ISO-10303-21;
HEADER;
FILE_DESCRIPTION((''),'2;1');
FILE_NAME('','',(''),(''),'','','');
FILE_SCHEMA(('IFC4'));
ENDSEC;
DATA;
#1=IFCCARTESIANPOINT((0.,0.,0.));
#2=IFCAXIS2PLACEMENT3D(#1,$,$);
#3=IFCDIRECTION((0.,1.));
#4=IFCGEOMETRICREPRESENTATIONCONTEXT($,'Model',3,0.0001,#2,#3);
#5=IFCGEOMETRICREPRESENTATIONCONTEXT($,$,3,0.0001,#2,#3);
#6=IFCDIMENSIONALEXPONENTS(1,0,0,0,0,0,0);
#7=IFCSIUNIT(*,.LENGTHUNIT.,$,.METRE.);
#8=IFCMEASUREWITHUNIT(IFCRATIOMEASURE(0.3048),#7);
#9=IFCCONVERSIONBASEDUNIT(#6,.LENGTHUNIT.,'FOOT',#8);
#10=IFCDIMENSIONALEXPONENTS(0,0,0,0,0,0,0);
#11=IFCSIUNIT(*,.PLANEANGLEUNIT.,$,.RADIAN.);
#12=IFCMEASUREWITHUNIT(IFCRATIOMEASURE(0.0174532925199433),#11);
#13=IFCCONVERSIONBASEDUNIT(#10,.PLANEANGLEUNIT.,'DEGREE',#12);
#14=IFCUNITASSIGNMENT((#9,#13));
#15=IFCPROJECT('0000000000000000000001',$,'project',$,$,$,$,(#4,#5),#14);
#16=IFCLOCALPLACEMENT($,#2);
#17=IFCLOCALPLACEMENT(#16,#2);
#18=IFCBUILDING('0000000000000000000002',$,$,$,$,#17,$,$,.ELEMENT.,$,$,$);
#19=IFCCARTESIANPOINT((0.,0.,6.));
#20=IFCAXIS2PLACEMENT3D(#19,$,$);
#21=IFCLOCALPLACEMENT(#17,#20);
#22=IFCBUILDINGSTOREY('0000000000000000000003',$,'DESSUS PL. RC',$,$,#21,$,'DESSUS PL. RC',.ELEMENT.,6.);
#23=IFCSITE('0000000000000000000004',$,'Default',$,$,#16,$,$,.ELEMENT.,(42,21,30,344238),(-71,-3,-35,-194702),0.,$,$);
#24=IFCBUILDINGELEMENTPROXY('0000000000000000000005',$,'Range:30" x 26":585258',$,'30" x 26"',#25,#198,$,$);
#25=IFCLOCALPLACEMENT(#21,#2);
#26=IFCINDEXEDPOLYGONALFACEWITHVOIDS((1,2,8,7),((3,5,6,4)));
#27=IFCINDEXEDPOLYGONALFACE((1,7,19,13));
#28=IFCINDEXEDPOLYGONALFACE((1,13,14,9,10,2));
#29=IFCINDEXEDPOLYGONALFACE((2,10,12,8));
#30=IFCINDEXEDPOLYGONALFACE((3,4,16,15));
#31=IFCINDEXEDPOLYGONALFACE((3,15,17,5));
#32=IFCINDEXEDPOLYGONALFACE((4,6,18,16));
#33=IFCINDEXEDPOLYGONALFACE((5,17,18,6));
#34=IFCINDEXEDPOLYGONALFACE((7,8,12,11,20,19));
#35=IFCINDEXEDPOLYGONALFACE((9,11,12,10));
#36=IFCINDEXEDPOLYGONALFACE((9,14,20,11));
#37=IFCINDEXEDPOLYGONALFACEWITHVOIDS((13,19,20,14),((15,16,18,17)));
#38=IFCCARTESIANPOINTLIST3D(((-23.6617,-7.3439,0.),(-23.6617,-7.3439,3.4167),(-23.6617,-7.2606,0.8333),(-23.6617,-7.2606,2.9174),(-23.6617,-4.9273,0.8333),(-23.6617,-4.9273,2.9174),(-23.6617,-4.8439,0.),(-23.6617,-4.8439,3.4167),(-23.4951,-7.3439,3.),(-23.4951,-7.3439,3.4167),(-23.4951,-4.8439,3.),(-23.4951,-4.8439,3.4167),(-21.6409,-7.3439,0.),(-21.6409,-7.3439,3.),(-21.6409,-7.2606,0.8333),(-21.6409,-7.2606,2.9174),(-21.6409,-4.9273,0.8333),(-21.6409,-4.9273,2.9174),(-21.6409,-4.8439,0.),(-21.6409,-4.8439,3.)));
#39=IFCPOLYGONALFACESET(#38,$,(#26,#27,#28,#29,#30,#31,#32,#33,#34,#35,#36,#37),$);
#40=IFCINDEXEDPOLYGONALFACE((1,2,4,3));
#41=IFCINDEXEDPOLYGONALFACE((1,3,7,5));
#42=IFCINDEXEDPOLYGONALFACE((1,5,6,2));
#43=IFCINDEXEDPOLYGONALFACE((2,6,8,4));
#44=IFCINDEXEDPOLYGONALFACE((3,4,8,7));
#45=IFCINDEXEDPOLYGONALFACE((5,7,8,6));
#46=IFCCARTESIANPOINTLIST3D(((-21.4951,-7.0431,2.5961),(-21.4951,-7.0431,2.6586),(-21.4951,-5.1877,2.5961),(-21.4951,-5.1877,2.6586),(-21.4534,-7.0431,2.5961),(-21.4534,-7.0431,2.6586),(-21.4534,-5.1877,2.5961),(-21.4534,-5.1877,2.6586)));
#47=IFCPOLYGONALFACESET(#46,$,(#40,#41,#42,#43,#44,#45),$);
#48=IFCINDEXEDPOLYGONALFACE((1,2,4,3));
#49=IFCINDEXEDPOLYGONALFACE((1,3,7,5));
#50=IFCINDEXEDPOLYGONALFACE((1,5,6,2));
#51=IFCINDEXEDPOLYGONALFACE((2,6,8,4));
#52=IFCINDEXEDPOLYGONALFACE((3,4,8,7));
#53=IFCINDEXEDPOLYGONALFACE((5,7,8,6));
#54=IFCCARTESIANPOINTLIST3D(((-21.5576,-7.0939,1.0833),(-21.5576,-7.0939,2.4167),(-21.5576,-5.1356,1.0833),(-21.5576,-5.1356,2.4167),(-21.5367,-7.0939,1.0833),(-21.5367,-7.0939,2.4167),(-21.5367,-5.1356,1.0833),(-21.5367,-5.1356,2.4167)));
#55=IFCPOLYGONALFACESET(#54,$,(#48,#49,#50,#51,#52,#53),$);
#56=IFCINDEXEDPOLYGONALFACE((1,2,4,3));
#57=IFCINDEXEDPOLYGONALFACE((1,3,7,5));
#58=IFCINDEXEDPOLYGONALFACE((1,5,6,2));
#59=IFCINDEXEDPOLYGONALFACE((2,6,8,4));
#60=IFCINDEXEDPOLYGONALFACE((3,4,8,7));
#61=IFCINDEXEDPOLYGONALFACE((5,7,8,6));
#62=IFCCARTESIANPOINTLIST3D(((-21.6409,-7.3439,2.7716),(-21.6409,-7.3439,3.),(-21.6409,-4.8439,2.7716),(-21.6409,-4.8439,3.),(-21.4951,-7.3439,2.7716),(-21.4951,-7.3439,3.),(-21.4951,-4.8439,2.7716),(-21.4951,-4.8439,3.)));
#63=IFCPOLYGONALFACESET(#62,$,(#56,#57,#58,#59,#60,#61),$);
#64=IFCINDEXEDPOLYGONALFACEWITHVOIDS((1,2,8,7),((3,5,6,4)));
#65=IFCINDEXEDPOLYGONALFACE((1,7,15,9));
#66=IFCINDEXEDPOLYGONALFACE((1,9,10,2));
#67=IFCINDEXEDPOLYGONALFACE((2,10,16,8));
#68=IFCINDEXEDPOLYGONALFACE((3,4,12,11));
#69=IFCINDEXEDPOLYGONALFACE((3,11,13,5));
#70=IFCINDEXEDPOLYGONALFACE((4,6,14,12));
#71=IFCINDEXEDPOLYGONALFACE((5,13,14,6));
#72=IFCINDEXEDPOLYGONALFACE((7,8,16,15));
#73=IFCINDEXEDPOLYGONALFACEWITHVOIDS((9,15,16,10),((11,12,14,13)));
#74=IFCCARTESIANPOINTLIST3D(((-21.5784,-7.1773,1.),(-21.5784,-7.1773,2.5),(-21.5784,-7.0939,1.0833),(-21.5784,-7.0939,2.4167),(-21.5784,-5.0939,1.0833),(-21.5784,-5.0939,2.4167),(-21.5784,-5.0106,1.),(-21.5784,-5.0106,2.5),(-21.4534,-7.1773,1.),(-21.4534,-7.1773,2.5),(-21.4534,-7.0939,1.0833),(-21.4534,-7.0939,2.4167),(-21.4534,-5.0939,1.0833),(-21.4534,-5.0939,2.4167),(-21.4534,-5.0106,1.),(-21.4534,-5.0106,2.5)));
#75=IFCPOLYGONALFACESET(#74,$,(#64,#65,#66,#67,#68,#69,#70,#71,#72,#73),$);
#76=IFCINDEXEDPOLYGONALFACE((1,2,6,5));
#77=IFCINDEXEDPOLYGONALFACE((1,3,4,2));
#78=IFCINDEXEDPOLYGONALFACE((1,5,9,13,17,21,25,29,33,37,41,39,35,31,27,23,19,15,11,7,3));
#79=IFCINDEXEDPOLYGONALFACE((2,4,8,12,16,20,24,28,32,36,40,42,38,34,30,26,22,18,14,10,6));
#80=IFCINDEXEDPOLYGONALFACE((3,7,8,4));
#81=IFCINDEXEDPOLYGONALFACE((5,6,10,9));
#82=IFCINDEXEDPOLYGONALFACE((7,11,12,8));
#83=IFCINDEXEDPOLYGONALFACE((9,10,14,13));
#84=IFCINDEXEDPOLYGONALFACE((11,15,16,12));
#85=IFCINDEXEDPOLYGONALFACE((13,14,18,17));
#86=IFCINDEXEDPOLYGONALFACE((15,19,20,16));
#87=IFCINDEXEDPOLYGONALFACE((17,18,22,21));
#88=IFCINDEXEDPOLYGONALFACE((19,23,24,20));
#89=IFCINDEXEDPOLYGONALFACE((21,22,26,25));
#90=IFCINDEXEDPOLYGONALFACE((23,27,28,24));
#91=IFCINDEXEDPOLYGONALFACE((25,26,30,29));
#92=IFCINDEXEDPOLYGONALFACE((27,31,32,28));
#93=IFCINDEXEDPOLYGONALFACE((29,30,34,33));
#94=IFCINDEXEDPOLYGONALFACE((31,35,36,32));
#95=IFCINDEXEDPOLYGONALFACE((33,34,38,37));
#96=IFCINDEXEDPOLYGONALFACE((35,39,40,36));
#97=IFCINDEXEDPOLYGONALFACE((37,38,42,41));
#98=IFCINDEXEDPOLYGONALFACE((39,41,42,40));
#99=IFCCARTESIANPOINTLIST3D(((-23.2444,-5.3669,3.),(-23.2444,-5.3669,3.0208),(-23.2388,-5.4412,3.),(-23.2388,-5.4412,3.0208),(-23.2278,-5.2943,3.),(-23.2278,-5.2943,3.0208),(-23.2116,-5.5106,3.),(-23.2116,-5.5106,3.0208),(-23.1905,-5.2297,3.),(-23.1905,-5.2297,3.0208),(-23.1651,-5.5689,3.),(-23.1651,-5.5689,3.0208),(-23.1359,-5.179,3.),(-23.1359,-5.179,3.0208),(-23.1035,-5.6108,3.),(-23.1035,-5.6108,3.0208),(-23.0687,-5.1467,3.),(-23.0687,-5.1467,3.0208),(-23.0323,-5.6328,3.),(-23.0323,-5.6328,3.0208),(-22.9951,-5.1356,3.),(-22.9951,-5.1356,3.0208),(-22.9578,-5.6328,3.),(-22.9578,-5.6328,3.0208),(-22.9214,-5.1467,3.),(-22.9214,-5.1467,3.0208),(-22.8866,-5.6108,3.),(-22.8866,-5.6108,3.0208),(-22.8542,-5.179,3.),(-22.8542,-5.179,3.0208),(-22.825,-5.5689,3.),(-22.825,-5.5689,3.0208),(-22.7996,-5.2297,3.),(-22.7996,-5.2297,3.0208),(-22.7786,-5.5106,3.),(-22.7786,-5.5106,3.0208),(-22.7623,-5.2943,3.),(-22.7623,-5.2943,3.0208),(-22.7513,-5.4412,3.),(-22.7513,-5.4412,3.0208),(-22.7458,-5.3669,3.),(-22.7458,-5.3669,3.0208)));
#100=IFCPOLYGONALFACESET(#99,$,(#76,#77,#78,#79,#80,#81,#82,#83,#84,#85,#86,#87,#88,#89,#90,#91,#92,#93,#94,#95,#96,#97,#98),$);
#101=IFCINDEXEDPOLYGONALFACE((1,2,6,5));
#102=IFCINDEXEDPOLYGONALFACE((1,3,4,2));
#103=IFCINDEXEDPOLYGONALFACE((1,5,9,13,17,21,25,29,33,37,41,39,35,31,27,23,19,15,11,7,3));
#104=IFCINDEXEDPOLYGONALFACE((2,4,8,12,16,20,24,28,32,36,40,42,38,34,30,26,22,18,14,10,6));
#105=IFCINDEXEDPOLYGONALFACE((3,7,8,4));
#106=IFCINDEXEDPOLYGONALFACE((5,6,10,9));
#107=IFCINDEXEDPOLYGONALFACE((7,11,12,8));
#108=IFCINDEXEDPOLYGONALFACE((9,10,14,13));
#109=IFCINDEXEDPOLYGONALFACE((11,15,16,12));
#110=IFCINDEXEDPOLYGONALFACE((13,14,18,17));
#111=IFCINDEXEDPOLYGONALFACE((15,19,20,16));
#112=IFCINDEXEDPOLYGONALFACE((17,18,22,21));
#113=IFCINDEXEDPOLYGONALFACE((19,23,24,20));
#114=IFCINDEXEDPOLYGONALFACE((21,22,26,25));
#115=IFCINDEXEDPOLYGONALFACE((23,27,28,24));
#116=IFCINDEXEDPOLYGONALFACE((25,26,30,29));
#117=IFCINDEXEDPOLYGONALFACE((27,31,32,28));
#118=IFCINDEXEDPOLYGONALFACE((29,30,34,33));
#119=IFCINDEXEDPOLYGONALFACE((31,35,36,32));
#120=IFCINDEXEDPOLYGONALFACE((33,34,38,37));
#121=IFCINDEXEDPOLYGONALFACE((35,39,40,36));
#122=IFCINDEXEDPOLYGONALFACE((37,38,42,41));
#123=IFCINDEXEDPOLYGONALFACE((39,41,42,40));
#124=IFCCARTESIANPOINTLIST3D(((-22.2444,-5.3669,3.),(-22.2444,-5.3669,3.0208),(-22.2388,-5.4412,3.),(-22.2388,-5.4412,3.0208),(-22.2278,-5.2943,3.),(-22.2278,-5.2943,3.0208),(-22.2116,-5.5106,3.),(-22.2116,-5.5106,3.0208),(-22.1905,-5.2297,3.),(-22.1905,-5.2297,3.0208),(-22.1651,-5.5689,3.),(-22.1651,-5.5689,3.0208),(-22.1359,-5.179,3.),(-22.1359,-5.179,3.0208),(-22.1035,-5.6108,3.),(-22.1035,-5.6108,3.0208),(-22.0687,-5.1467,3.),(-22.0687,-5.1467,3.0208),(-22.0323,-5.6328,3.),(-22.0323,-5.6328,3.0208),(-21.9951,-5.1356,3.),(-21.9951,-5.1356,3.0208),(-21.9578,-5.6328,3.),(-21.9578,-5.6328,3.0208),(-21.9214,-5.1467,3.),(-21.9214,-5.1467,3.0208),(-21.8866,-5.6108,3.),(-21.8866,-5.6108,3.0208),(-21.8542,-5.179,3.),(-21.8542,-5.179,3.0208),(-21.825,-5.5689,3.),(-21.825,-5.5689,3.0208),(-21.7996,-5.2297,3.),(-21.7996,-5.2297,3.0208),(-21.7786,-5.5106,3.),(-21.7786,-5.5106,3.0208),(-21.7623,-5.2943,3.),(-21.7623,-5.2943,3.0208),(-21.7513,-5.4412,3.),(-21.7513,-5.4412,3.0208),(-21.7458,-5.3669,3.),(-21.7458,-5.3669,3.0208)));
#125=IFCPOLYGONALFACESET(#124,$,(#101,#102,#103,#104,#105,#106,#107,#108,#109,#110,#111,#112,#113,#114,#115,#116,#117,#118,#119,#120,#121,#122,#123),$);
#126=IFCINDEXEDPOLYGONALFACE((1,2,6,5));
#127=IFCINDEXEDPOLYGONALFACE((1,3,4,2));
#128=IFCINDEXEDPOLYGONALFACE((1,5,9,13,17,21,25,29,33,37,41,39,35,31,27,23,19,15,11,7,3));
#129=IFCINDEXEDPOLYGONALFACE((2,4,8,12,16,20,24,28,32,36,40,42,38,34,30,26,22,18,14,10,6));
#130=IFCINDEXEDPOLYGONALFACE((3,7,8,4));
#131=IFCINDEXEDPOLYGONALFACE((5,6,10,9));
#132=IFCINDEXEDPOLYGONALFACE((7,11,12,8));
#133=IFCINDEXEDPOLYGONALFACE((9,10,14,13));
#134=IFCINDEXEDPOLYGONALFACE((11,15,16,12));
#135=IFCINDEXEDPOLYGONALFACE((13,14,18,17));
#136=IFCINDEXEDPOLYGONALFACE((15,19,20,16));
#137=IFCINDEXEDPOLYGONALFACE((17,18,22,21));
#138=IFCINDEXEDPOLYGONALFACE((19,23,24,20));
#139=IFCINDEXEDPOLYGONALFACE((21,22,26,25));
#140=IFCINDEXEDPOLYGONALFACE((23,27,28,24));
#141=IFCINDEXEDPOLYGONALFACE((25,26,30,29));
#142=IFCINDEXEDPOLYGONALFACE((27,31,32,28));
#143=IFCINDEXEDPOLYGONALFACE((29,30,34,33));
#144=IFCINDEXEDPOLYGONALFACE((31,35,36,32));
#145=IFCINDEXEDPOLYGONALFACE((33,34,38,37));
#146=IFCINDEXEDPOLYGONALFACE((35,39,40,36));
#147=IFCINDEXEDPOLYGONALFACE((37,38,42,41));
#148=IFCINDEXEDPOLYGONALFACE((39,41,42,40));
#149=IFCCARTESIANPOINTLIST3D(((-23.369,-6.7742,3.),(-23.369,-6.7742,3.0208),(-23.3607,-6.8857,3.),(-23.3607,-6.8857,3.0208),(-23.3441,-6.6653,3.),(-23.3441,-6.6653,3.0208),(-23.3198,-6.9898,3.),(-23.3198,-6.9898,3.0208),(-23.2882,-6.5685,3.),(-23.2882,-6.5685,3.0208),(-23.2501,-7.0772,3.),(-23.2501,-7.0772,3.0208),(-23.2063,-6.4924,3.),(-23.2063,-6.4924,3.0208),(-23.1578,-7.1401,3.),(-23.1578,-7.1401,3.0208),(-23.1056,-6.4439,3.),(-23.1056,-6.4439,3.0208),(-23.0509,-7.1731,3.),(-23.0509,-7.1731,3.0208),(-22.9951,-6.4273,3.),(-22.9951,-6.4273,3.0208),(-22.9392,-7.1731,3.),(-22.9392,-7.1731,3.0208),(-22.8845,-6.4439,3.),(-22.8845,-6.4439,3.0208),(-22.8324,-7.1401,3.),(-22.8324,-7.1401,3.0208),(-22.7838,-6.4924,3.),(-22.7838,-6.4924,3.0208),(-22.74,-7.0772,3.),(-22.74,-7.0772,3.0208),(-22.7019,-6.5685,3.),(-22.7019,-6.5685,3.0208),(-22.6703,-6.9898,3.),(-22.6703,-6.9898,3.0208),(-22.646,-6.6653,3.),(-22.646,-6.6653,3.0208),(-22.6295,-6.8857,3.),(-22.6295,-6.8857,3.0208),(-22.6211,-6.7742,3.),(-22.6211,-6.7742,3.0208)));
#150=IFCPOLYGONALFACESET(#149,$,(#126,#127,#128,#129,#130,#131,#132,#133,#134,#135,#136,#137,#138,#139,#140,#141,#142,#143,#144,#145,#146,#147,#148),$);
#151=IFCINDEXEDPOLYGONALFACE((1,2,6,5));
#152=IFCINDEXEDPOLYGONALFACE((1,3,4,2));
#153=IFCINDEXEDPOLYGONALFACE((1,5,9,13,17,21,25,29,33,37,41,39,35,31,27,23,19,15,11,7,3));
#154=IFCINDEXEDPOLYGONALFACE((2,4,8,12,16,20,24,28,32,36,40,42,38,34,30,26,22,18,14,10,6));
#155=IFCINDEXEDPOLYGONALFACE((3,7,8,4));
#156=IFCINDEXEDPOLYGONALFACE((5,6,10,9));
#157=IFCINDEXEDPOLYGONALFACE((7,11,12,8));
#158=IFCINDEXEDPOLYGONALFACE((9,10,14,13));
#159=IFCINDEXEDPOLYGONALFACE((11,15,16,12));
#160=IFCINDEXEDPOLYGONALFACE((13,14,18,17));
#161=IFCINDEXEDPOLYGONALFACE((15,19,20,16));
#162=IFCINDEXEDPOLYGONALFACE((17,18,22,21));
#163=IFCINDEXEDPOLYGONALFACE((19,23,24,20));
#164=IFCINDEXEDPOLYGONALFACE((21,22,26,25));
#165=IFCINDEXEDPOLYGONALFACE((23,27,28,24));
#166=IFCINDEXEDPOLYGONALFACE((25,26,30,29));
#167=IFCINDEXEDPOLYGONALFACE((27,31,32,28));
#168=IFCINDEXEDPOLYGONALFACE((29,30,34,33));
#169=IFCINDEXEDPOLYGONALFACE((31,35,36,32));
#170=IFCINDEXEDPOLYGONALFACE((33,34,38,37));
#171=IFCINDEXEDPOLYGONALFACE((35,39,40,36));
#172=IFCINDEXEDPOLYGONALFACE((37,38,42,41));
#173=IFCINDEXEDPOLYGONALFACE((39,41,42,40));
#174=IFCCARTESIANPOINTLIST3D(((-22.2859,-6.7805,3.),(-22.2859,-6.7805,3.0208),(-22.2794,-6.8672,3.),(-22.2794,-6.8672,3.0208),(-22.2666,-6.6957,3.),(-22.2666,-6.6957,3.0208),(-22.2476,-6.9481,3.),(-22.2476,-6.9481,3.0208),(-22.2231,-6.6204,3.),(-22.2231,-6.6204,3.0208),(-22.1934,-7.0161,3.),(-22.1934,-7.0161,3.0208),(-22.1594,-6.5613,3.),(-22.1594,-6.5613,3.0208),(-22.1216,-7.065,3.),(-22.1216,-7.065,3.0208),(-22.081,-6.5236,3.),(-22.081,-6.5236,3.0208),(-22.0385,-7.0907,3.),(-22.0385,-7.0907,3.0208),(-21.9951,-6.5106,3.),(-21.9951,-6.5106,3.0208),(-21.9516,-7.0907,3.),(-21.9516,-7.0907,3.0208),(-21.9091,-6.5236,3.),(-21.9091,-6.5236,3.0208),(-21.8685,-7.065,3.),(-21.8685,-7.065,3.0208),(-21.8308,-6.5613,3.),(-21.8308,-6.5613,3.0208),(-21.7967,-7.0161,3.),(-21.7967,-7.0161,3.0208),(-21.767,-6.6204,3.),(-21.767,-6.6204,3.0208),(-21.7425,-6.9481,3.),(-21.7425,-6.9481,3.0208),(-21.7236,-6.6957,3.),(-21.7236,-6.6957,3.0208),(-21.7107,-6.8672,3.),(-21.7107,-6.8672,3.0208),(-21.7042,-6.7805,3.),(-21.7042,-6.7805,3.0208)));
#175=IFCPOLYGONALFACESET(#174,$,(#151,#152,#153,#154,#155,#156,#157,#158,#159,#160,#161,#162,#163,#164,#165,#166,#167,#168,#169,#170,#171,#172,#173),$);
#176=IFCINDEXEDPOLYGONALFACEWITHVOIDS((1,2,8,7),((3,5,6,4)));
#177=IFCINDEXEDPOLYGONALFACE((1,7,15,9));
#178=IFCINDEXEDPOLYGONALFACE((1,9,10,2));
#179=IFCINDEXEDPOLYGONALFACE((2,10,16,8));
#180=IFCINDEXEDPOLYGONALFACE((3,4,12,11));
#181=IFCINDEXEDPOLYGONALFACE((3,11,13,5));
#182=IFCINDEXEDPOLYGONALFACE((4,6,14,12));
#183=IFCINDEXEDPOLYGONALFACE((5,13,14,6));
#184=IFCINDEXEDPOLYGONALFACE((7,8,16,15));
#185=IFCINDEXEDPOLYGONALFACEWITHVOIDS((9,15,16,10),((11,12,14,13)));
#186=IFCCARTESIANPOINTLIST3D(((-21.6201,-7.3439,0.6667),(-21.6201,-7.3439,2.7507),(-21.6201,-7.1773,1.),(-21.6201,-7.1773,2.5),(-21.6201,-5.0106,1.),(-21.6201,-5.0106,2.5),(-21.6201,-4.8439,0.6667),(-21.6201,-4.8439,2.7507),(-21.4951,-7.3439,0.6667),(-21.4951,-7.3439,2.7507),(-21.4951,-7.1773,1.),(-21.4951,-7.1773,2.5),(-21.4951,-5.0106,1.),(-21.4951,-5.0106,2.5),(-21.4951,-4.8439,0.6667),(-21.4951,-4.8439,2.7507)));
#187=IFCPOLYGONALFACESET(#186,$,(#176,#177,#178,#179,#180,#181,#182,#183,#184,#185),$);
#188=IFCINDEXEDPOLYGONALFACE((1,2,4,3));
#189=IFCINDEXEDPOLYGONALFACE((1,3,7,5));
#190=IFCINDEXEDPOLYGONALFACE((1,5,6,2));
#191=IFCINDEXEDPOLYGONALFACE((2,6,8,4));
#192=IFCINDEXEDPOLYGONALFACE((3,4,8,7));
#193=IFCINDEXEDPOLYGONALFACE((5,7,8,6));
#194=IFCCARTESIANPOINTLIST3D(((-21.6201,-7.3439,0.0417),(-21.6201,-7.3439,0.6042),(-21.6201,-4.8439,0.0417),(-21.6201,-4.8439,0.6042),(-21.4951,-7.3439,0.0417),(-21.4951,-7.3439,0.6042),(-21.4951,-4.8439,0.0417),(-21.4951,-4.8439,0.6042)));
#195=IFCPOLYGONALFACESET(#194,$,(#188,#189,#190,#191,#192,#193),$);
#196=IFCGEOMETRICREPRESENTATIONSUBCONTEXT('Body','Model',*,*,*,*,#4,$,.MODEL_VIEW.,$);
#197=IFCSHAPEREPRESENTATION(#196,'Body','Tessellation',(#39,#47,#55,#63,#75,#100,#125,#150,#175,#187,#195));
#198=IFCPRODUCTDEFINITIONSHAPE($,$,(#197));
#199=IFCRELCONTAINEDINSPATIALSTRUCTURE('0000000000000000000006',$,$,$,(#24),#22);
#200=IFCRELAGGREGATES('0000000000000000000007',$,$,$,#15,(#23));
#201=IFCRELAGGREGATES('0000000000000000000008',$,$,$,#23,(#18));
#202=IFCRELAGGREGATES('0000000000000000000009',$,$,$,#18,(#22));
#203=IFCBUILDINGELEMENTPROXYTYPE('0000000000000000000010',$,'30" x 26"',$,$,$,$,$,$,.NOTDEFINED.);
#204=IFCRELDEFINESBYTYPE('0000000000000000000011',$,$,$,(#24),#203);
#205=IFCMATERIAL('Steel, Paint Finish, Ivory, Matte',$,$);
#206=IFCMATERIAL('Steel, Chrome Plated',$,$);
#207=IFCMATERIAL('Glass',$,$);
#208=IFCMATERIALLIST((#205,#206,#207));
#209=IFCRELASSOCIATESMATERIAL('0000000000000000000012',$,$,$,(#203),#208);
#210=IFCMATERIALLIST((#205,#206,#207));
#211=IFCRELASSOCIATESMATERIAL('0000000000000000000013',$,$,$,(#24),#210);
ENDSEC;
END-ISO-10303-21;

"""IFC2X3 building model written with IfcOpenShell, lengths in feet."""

from ifc_helpers import new_model, entity, si_unit, converted_unit, direction, frame, frame_2d, origin, origin_2d_with_axis, place, context, subcontext, project, spatial, polyline, rectangle, circle, outline, extrude, source, transform, mapped, material, material_list, type_object, type_shapes, element, save


model = new_model("IFC2X3")

# Units and contexts
model_context = context("Model", 3, precision=0.0001, world=origin(), true_north=direction((0.0, 1.0)))
context_of_model = context(None, 3, precision=0.0001, world=origin(), true_north=direction((0.0, 1.0)))
body_context = subcontext(model_context, "Body", "Model", "MODEL_VIEW")
ifc_project = project(units=[converted_unit("LENGTHUNIT", "FOOT", entity("IfcRatioMeasure", 0.3048), si_unit("LENGTHUNIT", "METRE"), dimensions=[1, 0, 0, 0, 0, 0, 0]), converted_unit("PLANEANGLEUNIT", "DEGREE", entity("IfcRatioMeasure", 0.0174532925199433), si_unit("PLANEANGLEUNIT", "RADIAN"), dimensions=[0, 0, 0, 0, 0, 0, 0])], contexts=[model_context, context_of_model])

# Site, building, storey
site_placement = place(None, origin())
site = spatial("IfcSite", under=ifc_project, at=site_placement, Name="Default", CompositionType="ELEMENT", RefLatitude=(42, 21, 30, 344238), RefLongitude=(-71, -3, -35, -194702), RefElevation=0.0)
building_placement = place(site_placement, origin())
building = spatial("IfcBuilding", under=site, at=building_placement, CompositionType="ELEMENT")
storey_placement = place(building_placement, frame((0.0, 0.0, 6.0)))
storey = spatial("IfcBuildingStorey", under=building, at=storey_placement, Name="DESSUS PL. RC", LongName="DESSUS PL. RC", CompositionType="ELEMENT", Elevation=6.0)

# Building element proxy, opening
ifc_material_1 = material(Name="Steel, Paint Finish, Ivory, Matte")
ifc_material_2 = material(Name="Steel, Chrome Plated")
ifc_material_3 = material(Name="Glass")
ifc_material_list_1 = material_list([ifc_material_1, ifc_material_2, ifc_material_3])
ifc_material_list_2 = material_list([ifc_material_1, ifc_material_2, ifc_material_3])
building_element_proxy_type_1 = type_object("IfcBuildingElementProxyType", Name="30\" x 26\"", PredefinedType="NOTDEFINED", material=ifc_material_list_2)
shared_shape_1 = source(origin(), body_context, "Body", "SweptSolid", [
    extrude(outline(polyline([(-0.7292, -1.2778), (-0.5625, -1.2778), (-0.5625, -0.8611), (1.2917, -0.8611), (1.2917, 2.1389), (-0.7292, 2.1389), (-0.7292, -1.2778)])), frame((0.0, 1.4375, 2.1389), z_axis=(1.0, 0.0, 0.0), x_axis=(0.0, -1.0, 0.0)), (0.0, 0.0, 1.0), 2.5),
    extrude(rectangle(XDim=0.0417, YDim=1.8554, at=origin_2d_with_axis()), frame((1.2285, -0.0208, 2.5961), z_axis=(0.0, 0.0, 1.0), x_axis=(0.0, 1.0, 0.0)), (0.0, 0.0, 1.0), 0.0625),
    extrude(rectangle(XDim=0.0208, YDim=1.9583, at=frame_2d((0.0, 0.0), x_axis=(1.0, 0.0))), frame((1.2292, 0.0521, 1.0833), z_axis=(0.0, 0.0, 1.0), x_axis=(0.0, 1.0, 0.0)), (0.0, 0.0, 1.0), 1.3333),
    extrude(rectangle(XDim=0.1458, YDim=2.5, at=origin_2d_with_axis()), frame((1.25, 0.0729, 2.7716), z_axis=(0.0, 0.0, 1.0), x_axis=(0.0, 1.0, 0.0)), (0.0, 0.0, 1.0), 0.2284),
    extrude(outline(polyline([(-0.75, -1.0833), (0.75, -1.0833), (0.75, 1.0833), (-0.75, 1.0833), (-0.75, -1.0833)]), holes=[polyline([(-0.6667, -1.0), (-0.6667, 1.0), (0.6667, 1.0), (0.6667, -1.0), (-0.6667, -1.0)])]), frame((1.25, -0.0417, 1.75), z_axis=(0.0, 1.0, 0.0), x_axis=(0.0, 0.0, -1.0)), (0.0, 0.0, 1.0), 0.125),
    extrude(circle(Radius=0.25, at=frame_2d((0.0, 0.0), x_axis=(1.0, 0.0))), frame((1.9583, 1.5, 3.0)), (0.0, 0.0, 1.0), 0.0208),
    extrude(circle(Radius=0.25, at=frame_2d((0.0, 0.0), x_axis=(1.0, 0.0))), frame((1.9583, 0.5, 3.0)), (0.0, 0.0, 1.0), 0.0208),
    extrude(circle(Radius=0.375, at=frame_2d((0.0, 0.0), x_axis=(1.0, 0.0))), frame((0.5417, 1.5, 3.0)), (0.0, 0.0, 1.0), 0.0208),
    extrude(circle(Radius=0.2917, at=frame_2d((0.0, 0.0), x_axis=(1.0, 0.0))), frame((0.5417, 0.5, 3.0)), (0.0, 0.0, 1.0), 0.0208),
    extrude(rectangle(XDim=0.0833, YDim=2.3333, at=frame_2d((0.0, 0.0), x_axis=(1.0, 0.0))), frame((1.25, 2.125, 0.8333), z_axis=(0.0, 0.0, 1.0), x_axis=(0.0, -1.0, 0.0)), (0.0, 0.0, 1.0), 2.0841),
    extrude(outline(polyline([(-1.042, -1.25), (1.042, -1.25), (1.042, 1.25), (-1.042, 1.25), (-1.042, -1.25)]), holes=[polyline([(-0.7913, -1.0833), (-0.7913, 1.0833), (0.7087, 1.0833), (0.7087, -1.0833), (-0.7913, -1.0833)])]), frame((1.25, 0.0, 1.7087), z_axis=(0.0, 1.0, 0.0), x_axis=(0.0, 0.0, -1.0)), (0.0, 0.0, 1.0), 0.125),
    extrude(rectangle(XDim=0.125, YDim=2.5, at=origin_2d_with_axis()), frame((1.25, 0.0625, 0.0417), z_axis=(0.0, 0.0, 1.0), x_axis=(0.0, 1.0, 0.0)), (0.0, 0.0, 1.0), 0.5625),
])
type_shapes(building_element_proxy_type_1, [shared_shape_1])
proxy_1_placement = place(storey_placement, frame((-21.4951, -7.3439, 0.0), z_axis=(0.0, 0.0, 1.0), x_axis=(0.0, 1.0, 0.0)))
proxy_1 = element("IfcBuildingElementProxy", 1, at=proxy_1_placement, inside=storey, type_object=building_element_proxy_type_1, material=ifc_material_list_1, Name="Range:30\" x 26\":585258", ObjectType="30\" x 26\"", context=body_context, shape_type="MappedRepresentation", body=[
    mapped(shared_shape_1, transform((0.0, 0.0, 0.0), scale=1.0)),
])
opening_1_placement = place(storey_placement, frame((-21.4951, -7.3439, 6.0), z_axis=(0.0, 0.0, 1.0), x_axis=(-1.0, 0.0, 0.0)))
element("IfcOpeningElement", 2, at=opening_1_placement, cuts=proxy_1, ObjectType="Opening", context=body_context, shape_type="SweptSolid", body=[
    extrude(rectangle(XDim=2.0841, YDim=2.3333, at=frame_2d((0.0, 0.0), x_axis=(0.0, 1.0))), frame((2.1667, -1.25, -4.1246), z_axis=(-1.0, 0.0, 0.0), x_axis=(0.0, 1.0, 0.0)), (0.0, 0.0, 1.0), 2.0208),
])

save(model, "model.ifc")
